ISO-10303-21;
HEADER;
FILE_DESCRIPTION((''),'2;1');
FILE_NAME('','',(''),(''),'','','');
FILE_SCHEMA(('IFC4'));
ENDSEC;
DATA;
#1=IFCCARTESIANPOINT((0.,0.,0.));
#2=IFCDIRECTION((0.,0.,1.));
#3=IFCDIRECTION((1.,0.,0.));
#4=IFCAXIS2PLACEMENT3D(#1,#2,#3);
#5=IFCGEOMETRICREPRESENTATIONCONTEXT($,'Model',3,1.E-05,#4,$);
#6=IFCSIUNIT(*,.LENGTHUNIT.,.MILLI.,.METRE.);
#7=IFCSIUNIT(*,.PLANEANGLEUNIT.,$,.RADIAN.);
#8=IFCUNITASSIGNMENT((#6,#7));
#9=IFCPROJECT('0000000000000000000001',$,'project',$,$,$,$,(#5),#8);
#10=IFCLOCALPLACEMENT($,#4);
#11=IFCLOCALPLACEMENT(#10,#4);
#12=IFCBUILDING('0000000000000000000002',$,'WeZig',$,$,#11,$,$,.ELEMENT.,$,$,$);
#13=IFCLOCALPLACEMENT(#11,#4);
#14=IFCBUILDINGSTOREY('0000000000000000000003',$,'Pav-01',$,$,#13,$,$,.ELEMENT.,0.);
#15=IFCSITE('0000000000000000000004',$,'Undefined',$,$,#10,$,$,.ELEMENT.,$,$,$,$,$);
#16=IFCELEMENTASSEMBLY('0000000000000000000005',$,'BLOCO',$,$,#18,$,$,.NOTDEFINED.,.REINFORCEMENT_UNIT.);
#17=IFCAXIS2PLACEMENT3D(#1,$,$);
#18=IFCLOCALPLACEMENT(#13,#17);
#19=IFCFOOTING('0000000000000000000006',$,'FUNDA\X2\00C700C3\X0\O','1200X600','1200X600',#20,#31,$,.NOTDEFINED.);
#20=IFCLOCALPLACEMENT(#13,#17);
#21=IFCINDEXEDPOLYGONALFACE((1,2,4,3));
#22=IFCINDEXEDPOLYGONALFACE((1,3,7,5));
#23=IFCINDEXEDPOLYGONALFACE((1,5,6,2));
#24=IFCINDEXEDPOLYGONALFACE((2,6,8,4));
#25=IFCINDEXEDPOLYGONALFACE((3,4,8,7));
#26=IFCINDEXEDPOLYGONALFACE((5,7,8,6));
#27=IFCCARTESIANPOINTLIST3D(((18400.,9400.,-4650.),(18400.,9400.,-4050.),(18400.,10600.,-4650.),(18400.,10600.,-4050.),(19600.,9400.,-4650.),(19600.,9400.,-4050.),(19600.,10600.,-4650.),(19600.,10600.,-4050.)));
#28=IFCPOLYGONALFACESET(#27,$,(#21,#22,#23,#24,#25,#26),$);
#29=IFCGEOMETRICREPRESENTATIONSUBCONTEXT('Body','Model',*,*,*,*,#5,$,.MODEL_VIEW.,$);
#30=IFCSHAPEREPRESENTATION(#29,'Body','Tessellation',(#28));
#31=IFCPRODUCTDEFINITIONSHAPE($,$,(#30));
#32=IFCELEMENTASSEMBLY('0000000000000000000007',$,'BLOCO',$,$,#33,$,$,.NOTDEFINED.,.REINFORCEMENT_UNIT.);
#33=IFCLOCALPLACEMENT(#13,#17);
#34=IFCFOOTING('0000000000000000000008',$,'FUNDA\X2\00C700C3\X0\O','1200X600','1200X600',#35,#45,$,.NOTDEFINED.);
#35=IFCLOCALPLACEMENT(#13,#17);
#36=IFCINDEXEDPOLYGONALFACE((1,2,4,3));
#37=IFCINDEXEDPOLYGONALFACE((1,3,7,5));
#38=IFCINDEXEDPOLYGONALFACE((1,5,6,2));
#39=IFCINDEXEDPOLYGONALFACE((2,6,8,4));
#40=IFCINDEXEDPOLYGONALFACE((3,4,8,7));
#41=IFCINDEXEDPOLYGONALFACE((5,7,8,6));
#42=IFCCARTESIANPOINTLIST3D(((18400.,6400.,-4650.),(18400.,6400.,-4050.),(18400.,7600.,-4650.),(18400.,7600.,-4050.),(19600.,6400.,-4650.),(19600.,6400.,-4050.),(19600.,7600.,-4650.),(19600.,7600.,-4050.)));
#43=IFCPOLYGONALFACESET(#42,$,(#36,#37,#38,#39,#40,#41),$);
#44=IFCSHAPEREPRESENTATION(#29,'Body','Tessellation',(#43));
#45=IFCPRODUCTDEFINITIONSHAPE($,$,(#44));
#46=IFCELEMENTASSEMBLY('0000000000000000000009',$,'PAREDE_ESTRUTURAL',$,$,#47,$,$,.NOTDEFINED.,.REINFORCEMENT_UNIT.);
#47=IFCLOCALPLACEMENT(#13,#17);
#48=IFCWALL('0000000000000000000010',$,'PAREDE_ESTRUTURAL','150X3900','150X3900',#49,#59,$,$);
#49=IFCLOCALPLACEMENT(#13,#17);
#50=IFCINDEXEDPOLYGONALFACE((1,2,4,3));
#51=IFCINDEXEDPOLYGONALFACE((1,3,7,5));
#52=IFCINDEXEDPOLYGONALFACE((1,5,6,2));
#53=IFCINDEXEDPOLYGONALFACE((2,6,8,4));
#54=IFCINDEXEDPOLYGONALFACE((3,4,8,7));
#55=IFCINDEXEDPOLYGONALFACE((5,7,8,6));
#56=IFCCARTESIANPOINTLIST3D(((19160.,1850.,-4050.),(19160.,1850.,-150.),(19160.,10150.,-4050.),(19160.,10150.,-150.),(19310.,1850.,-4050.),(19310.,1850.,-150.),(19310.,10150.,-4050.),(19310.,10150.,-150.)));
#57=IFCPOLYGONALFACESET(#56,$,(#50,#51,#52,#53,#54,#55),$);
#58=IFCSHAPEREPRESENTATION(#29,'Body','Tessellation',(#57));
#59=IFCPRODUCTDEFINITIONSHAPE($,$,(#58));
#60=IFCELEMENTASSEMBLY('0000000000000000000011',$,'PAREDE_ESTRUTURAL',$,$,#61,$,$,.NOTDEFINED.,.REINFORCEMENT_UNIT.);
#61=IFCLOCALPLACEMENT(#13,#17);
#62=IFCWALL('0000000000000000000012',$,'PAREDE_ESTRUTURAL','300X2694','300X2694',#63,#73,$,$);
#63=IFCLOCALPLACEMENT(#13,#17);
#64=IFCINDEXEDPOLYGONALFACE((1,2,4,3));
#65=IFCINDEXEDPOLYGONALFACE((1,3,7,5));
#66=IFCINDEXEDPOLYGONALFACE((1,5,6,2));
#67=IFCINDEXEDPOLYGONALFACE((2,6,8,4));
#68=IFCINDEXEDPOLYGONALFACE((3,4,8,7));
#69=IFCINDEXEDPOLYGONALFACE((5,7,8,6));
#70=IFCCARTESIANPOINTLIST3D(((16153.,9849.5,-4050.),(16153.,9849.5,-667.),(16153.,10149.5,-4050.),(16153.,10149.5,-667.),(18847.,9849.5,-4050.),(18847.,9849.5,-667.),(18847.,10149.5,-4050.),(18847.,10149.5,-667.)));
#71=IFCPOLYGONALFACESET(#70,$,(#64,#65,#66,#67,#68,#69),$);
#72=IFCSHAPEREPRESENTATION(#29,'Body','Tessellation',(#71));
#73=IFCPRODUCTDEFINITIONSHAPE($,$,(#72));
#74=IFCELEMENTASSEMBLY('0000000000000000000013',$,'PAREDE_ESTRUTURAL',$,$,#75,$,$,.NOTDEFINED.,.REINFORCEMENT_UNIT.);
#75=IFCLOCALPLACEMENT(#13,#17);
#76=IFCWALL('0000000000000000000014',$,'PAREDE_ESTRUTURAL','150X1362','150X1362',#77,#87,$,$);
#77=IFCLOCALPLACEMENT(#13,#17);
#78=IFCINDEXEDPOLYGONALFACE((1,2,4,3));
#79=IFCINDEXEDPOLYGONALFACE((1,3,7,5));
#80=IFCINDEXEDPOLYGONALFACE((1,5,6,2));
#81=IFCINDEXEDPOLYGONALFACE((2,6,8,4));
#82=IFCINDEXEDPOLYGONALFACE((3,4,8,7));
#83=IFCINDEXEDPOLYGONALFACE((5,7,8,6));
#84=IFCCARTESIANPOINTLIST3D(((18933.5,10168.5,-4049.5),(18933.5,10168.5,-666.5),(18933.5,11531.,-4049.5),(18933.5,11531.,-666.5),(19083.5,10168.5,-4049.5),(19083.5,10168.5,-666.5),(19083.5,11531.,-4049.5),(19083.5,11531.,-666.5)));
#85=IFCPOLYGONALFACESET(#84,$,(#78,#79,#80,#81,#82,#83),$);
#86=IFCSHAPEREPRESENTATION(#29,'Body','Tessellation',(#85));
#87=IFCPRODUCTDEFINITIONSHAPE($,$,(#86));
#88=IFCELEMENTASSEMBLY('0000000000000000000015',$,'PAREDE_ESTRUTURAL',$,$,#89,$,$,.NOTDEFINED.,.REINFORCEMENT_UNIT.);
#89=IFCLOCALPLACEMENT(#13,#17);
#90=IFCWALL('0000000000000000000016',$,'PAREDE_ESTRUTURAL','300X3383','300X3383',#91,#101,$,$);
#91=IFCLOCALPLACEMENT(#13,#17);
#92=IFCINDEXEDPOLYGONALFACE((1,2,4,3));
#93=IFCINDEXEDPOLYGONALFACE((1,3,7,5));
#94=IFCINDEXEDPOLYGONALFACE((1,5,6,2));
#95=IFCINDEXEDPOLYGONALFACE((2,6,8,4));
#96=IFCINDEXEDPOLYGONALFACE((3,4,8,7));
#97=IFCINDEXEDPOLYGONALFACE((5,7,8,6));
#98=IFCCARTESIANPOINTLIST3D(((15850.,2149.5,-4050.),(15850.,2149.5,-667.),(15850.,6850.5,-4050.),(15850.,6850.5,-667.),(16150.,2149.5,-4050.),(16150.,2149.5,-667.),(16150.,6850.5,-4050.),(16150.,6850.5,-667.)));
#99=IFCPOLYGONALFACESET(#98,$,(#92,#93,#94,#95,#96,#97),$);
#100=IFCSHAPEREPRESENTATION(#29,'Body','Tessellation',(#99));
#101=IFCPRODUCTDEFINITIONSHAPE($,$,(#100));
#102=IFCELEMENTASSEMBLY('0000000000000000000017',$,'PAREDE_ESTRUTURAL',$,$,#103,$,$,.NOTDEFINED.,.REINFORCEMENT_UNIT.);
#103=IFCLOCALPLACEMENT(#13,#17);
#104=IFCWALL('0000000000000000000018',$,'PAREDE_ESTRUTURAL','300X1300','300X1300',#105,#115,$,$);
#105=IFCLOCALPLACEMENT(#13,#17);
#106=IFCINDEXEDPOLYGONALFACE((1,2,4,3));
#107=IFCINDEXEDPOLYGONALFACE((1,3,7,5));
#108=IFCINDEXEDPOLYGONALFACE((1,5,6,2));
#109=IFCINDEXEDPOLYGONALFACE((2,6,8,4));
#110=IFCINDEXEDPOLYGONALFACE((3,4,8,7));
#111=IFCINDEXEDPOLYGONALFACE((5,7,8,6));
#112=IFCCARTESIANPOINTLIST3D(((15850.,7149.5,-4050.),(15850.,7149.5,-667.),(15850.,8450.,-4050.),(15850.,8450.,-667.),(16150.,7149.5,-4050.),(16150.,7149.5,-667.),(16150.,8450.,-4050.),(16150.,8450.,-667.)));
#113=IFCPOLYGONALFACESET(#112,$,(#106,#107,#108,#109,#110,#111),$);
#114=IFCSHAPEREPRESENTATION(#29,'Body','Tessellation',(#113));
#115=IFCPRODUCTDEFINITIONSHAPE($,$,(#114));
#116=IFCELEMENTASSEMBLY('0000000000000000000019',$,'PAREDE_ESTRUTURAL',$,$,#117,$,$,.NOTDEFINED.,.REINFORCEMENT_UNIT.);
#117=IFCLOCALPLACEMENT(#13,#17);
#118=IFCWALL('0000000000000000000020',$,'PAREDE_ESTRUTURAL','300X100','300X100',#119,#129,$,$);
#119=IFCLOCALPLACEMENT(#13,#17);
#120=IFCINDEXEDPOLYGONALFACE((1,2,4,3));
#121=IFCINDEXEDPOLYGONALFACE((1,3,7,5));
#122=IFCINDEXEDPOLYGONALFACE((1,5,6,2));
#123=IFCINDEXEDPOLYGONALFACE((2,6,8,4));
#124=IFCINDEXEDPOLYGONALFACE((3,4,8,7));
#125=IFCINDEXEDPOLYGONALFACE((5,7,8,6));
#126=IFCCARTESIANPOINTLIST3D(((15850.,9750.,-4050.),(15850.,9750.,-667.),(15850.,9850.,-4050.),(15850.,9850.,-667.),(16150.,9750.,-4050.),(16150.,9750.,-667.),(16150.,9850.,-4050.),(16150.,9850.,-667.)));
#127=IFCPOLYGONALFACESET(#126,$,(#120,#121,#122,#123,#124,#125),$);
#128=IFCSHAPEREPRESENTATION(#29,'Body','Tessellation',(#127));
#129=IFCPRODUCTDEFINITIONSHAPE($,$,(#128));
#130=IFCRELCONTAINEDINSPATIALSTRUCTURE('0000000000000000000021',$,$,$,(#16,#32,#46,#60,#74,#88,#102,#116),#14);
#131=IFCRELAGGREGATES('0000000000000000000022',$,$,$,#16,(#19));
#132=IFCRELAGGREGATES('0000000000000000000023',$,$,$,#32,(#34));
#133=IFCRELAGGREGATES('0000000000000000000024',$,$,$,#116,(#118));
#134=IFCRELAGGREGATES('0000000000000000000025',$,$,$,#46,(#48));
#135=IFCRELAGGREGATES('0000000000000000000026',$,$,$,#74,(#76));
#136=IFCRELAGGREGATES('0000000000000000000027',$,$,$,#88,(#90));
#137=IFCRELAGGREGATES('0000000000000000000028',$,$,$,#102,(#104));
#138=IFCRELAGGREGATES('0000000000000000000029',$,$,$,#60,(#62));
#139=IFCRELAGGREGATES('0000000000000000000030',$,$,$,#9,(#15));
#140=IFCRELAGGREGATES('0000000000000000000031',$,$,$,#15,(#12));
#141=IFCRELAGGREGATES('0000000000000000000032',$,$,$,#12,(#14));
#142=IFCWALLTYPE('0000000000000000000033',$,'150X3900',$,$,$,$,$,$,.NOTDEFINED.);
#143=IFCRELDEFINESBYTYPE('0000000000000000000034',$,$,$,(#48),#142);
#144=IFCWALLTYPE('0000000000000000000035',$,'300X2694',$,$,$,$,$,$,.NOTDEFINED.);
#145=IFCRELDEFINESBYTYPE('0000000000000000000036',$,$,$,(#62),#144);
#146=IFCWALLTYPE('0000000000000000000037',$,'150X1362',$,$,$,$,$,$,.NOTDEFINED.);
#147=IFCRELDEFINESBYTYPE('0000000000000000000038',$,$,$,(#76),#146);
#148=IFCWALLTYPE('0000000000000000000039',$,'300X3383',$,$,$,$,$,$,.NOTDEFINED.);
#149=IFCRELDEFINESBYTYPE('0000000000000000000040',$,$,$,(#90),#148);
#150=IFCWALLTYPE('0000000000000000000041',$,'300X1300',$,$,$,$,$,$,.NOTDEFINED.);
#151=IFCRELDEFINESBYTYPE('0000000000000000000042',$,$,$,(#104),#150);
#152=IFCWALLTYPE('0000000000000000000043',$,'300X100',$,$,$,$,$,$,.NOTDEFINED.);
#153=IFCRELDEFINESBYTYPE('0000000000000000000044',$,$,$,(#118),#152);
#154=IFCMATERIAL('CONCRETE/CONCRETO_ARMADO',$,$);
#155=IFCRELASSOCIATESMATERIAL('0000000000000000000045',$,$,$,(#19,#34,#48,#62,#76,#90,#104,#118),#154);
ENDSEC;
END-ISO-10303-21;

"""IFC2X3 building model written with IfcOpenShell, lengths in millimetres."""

from ifc_helpers import new_model, si_unit, frame, frame_2d, origin_with_axes, origin_2d_with_axis, place, context, subcontext, project, spatial, rectangle, extrude, material, type_object, element, aggregate, save


model = new_model("IFC2X3")

# Units and contexts
model_context = context("Model", 3, precision=1e-05, world=origin_with_axes())
body_context = subcontext(model_context, "Body", "Model", "MODEL_VIEW")
ifc_project = project(units=[si_unit("LENGTHUNIT", "METRE", prefix="MILLI"), si_unit("PLANEANGLEUNIT", "RADIAN")], contexts=[model_context])

# Site, building, storey
site_placement = place(None, origin_with_axes())
site = spatial("IfcSite", under=ifc_project, at=site_placement, Name="Undefined", CompositionType="ELEMENT")
building_placement = place(site_placement, origin_with_axes())
building = spatial("IfcBuilding", under=site, at=building_placement, Name="WeZig", CompositionType="ELEMENT")
storey_placement = place(building_placement, origin_with_axes())
storey = spatial("IfcBuildingStorey", under=building, at=storey_placement, Name="Pav-01", CompositionType="ELEMENT", Elevation=0.0)

# Element assemblies, footings
assembly_1_placement = place(storey_placement, origin_with_axes())
assembly_1 = element("IfcElementAssembly", 1, at=assembly_1_placement, inside=storey, Name="BLOCO", AssemblyPlace="NOTDEFINED", PredefinedType="REINFORCEMENT_UNIT")
ifc_material_1 = material(Name="CONCRETE/CONCRETO_ARMADO")
footing_1_placement = place(assembly_1_placement, frame((19000.0, 10000.0, -4650.0), z_axis=(0.0, 1.0, 0.0), x_axis=(0.0, 0.0, 1.0)))
footing_1 = element("IfcFooting", 2, at=footing_1_placement, material=ifc_material_1, Name="FUNDAÇÃO", Description="1200X600", ObjectType="1200X600", PredefinedType="NOTDEFINED", context=body_context, shape_type="SweptSolid", body=[
    extrude(rectangle(XDim=1200.0, YDim=1200.0, at=origin_2d_with_axis()), frame((600.0, 0.0, 0.0), z_axis=(-1.0, 0.0, 0.0), x_axis=(0.0, -1.0, 0.0)), (0.0, 0.0, 1.0), 600.0),
])
aggregate(assembly_1, [footing_1])
assembly_2_placement = place(storey_placement, origin_with_axes())
assembly_2 = element("IfcElementAssembly", 3, at=assembly_2_placement, inside=storey, Name="BLOCO", AssemblyPlace="NOTDEFINED", PredefinedType="REINFORCEMENT_UNIT")
footing_2_placement = place(assembly_2_placement, frame((19000.0, 7000.0, -4650.0), z_axis=(0.0, 1.0, 0.0), x_axis=(0.0, 0.0, 1.0)))
footing_2 = element("IfcFooting", 4, at=footing_2_placement, material=ifc_material_1, Name="FUNDAÇÃO", Description="1200X600", ObjectType="1200X600", PredefinedType="NOTDEFINED", context=body_context, shape_type="SweptSolid", body=[
    extrude(rectangle(XDim=1200.0, YDim=1200.0, at=origin_2d_with_axis()), frame((600.0, 0.0, 0.0), z_axis=(-1.0, 0.0, 0.0), x_axis=(0.0, -1.0, 0.0)), (0.0, 0.0, 1.0), 600.0),
])
aggregate(assembly_2, [footing_2])

# Element assemblies, walls
assembly_3_placement = place(storey_placement, origin_with_axes())
assembly_3 = element("IfcElementAssembly", 5, at=assembly_3_placement, inside=storey, Name="PAREDE_ESTRUTURAL", AssemblyPlace="NOTDEFINED", PredefinedType="REINFORCEMENT_UNIT")
wall_type_1 = type_object("IfcWallType", Name="150X3900", PredefinedType="NOTDEFINED")
wall_1_placement = place(assembly_3_placement, frame((19235.0, 10150.0, -4050.0), z_axis=(0.0, 0.0, 1.0), x_axis=(0.000004, -1.0, 0.0)))
wall_1 = element("IfcWall", 6, at=wall_1_placement, type_object=wall_type_1, material=ifc_material_1, Name="PAREDE_ESTRUTURAL", Description="150X3900", ObjectType="150X3900", context=body_context, shape_type="SweptSolid", body=[
    extrude(rectangle(XDim=8300.0, YDim=150.0, at=frame_2d((0.0, 4150.0), x_axis=(0.0, -1.0))), frame((0.0, 0.0, 0.0), z_axis=(0.0, 0.0, 1.0), x_axis=(0.0, -1.0, 0.0)), (0.0, 0.0, 1.0), 3900.0),
])
assembly_4_placement = place(storey_placement, origin_with_axes())
assembly_4 = element("IfcElementAssembly", 7, at=assembly_4_placement, inside=storey, Name="PAREDE_ESTRUTURAL", AssemblyPlace="NOTDEFINED", PredefinedType="REINFORCEMENT_UNIT")
wall_type_2 = type_object("IfcWallType", Name="300X2694", PredefinedType="NOTDEFINED")
wall_2_placement = place(assembly_4_placement, frame((18847.0, 9999.5, -3705.5), z_axis=(0.0, 0.0, 1.0), x_axis=(-1.0, 0.0, 0.0)))
wall_2 = element("IfcWall", 8, at=wall_2_placement, type_object=wall_type_2, material=ifc_material_1, Name="PAREDE_ESTRUTURAL", Description="300X2694", ObjectType="300X2694", context=body_context, shape_type="SweptSolid", body=[
    extrude(rectangle(XDim=2694.0, YDim=300.0, at=frame_2d((0.0, 1347.0), x_axis=(0.0, -1.0))), frame((0.0, 0.0, -344.5), z_axis=(0.0, 0.0, 1.0), x_axis=(0.0, -1.0, 0.0)), (0.0, 0.0, 1.0), 3383.0),
])
assembly_5_placement = place(storey_placement, origin_with_axes())
assembly_5 = element("IfcElementAssembly", 9, at=assembly_5_placement, inside=storey, Name="PAREDE_ESTRUTURAL", AssemblyPlace="NOTDEFINED", PredefinedType="REINFORCEMENT_UNIT")
wall_type_3 = type_object("IfcWallType", Name="150X1362", PredefinedType="NOTDEFINED")
wall_3_placement = place(assembly_5_placement, frame((19008.5, 10168.5, -3039.3), z_axis=(0.0, 0.0, 1.0), x_axis=(0.0, 1.0, 0.0)))
wall_3 = element("IfcWall", 10, at=wall_3_placement, type_object=wall_type_3, material=ifc_material_1, Name="PAREDE_ESTRUTURAL", Description="150X1362", ObjectType="150X1362", context=body_context, shape_type="SweptSolid", body=[
    extrude(rectangle(XDim=1362.5, YDim=150.0, at=frame_2d((0.0, 681.2), x_axis=(0.0, -1.0))), frame((0.0, 0.0, -1010.2), z_axis=(0.0, 0.0, 1.0), x_axis=(0.0, -1.0, 0.0)), (0.0, 0.0, 1.0), 3383.0),
])
assembly_6_placement = place(storey_placement, origin_with_axes())
assembly_6 = element("IfcElementAssembly", 11, at=assembly_6_placement, inside=storey, Name="PAREDE_ESTRUTURAL", AssemblyPlace="NOTDEFINED", PredefinedType="REINFORCEMENT_UNIT")
wall_type_4 = type_object("IfcWallType", Name="300X3383", PredefinedType="NOTDEFINED")
wall_4_placement = place(assembly_6_placement, frame((16000.0, 6850.5, -4050.0), z_axis=(0.0, 0.0, 1.0), x_axis=(0.0, -1.0, 0.0)))
wall_4 = element("IfcWall", 12, at=wall_4_placement, type_object=wall_type_4, material=ifc_material_1, Name="PAREDE_ESTRUTURAL", Description="300X3383", ObjectType="300X3383", context=body_context, shape_type="SweptSolid", body=[
    extrude(rectangle(XDim=4701.0, YDim=300.0, at=frame_2d((0.0, 2350.5), x_axis=(0.0, -1.0))), frame((0.0, 0.0, 0.0), z_axis=(0.0, 0.0, 1.0), x_axis=(0.0, -1.0, 0.0)), (0.0, 0.0, 1.0), 3383.0),
])
assembly_7_placement = place(storey_placement, origin_with_axes())
assembly_7 = element("IfcElementAssembly", 13, at=assembly_7_placement, inside=storey, Name="PAREDE_ESTRUTURAL", AssemblyPlace="NOTDEFINED", PredefinedType="REINFORCEMENT_UNIT")
wall_type_5 = type_object("IfcWallType", Name="300X1300", PredefinedType="NOTDEFINED")
wall_5_placement = place(assembly_7_placement, frame((16000.0, 8450.0, -3008.8), z_axis=(0.0, 0.0, 1.0), x_axis=(0.0, -1.0, 0.0)))
wall_5 = element("IfcWall", 14, at=wall_5_placement, type_object=wall_type_5, material=ifc_material_1, Name="PAREDE_ESTRUTURAL", Description="300X1300", ObjectType="300X1300", context=body_context, shape_type="SweptSolid", body=[
    extrude(rectangle(XDim=1300.5, YDim=300.0, at=frame_2d((0.0, 650.2), x_axis=(0.0, -1.0))), frame((0.0, 0.0, -1041.2), z_axis=(0.0, 0.0, 1.0), x_axis=(0.0, -1.0, 0.0)), (0.0, 0.0, 1.0), 3383.0),
])
assembly_8_placement = place(storey_placement, origin_with_axes())
assembly_8 = element("IfcElementAssembly", 15, at=assembly_8_placement, inside=storey, Name="PAREDE_ESTRUTURAL", AssemblyPlace="NOTDEFINED", PredefinedType="REINFORCEMENT_UNIT")
wall_type_6 = type_object("IfcWallType", Name="300X100", PredefinedType="NOTDEFINED")
wall_6_placement = place(assembly_8_placement, frame((16000.0, 9850.0, -2408.5), z_axis=(0.0, 0.0, 1.0), x_axis=(0.000002, -1.0, 0.0)))
wall_6 = element("IfcWall", 16, at=wall_6_placement, type_object=wall_type_6, material=ifc_material_1, Name="PAREDE_ESTRUTURAL", Description="300X100", ObjectType="300X100", context=body_context, shape_type="SweptSolid", body=[
    extrude(rectangle(XDim=100.0, YDim=300.0, at=frame_2d((0.0, 50.0), x_axis=(0.0, -1.0))), frame((0.0, 0.0, -1641.5), z_axis=(0.0, 0.0, 1.0), x_axis=(0.0, -1.0, 0.0)), (0.0, 0.0, 1.0), 3383.0),
])
aggregate(assembly_8, [wall_6])

aggregate(assembly_3, [wall_1])
aggregate(assembly_5, [wall_3])

aggregate(assembly_6, [wall_4])
aggregate(assembly_7, [wall_5])
aggregate(assembly_4, [wall_2])

save(model, "model.ifc")
